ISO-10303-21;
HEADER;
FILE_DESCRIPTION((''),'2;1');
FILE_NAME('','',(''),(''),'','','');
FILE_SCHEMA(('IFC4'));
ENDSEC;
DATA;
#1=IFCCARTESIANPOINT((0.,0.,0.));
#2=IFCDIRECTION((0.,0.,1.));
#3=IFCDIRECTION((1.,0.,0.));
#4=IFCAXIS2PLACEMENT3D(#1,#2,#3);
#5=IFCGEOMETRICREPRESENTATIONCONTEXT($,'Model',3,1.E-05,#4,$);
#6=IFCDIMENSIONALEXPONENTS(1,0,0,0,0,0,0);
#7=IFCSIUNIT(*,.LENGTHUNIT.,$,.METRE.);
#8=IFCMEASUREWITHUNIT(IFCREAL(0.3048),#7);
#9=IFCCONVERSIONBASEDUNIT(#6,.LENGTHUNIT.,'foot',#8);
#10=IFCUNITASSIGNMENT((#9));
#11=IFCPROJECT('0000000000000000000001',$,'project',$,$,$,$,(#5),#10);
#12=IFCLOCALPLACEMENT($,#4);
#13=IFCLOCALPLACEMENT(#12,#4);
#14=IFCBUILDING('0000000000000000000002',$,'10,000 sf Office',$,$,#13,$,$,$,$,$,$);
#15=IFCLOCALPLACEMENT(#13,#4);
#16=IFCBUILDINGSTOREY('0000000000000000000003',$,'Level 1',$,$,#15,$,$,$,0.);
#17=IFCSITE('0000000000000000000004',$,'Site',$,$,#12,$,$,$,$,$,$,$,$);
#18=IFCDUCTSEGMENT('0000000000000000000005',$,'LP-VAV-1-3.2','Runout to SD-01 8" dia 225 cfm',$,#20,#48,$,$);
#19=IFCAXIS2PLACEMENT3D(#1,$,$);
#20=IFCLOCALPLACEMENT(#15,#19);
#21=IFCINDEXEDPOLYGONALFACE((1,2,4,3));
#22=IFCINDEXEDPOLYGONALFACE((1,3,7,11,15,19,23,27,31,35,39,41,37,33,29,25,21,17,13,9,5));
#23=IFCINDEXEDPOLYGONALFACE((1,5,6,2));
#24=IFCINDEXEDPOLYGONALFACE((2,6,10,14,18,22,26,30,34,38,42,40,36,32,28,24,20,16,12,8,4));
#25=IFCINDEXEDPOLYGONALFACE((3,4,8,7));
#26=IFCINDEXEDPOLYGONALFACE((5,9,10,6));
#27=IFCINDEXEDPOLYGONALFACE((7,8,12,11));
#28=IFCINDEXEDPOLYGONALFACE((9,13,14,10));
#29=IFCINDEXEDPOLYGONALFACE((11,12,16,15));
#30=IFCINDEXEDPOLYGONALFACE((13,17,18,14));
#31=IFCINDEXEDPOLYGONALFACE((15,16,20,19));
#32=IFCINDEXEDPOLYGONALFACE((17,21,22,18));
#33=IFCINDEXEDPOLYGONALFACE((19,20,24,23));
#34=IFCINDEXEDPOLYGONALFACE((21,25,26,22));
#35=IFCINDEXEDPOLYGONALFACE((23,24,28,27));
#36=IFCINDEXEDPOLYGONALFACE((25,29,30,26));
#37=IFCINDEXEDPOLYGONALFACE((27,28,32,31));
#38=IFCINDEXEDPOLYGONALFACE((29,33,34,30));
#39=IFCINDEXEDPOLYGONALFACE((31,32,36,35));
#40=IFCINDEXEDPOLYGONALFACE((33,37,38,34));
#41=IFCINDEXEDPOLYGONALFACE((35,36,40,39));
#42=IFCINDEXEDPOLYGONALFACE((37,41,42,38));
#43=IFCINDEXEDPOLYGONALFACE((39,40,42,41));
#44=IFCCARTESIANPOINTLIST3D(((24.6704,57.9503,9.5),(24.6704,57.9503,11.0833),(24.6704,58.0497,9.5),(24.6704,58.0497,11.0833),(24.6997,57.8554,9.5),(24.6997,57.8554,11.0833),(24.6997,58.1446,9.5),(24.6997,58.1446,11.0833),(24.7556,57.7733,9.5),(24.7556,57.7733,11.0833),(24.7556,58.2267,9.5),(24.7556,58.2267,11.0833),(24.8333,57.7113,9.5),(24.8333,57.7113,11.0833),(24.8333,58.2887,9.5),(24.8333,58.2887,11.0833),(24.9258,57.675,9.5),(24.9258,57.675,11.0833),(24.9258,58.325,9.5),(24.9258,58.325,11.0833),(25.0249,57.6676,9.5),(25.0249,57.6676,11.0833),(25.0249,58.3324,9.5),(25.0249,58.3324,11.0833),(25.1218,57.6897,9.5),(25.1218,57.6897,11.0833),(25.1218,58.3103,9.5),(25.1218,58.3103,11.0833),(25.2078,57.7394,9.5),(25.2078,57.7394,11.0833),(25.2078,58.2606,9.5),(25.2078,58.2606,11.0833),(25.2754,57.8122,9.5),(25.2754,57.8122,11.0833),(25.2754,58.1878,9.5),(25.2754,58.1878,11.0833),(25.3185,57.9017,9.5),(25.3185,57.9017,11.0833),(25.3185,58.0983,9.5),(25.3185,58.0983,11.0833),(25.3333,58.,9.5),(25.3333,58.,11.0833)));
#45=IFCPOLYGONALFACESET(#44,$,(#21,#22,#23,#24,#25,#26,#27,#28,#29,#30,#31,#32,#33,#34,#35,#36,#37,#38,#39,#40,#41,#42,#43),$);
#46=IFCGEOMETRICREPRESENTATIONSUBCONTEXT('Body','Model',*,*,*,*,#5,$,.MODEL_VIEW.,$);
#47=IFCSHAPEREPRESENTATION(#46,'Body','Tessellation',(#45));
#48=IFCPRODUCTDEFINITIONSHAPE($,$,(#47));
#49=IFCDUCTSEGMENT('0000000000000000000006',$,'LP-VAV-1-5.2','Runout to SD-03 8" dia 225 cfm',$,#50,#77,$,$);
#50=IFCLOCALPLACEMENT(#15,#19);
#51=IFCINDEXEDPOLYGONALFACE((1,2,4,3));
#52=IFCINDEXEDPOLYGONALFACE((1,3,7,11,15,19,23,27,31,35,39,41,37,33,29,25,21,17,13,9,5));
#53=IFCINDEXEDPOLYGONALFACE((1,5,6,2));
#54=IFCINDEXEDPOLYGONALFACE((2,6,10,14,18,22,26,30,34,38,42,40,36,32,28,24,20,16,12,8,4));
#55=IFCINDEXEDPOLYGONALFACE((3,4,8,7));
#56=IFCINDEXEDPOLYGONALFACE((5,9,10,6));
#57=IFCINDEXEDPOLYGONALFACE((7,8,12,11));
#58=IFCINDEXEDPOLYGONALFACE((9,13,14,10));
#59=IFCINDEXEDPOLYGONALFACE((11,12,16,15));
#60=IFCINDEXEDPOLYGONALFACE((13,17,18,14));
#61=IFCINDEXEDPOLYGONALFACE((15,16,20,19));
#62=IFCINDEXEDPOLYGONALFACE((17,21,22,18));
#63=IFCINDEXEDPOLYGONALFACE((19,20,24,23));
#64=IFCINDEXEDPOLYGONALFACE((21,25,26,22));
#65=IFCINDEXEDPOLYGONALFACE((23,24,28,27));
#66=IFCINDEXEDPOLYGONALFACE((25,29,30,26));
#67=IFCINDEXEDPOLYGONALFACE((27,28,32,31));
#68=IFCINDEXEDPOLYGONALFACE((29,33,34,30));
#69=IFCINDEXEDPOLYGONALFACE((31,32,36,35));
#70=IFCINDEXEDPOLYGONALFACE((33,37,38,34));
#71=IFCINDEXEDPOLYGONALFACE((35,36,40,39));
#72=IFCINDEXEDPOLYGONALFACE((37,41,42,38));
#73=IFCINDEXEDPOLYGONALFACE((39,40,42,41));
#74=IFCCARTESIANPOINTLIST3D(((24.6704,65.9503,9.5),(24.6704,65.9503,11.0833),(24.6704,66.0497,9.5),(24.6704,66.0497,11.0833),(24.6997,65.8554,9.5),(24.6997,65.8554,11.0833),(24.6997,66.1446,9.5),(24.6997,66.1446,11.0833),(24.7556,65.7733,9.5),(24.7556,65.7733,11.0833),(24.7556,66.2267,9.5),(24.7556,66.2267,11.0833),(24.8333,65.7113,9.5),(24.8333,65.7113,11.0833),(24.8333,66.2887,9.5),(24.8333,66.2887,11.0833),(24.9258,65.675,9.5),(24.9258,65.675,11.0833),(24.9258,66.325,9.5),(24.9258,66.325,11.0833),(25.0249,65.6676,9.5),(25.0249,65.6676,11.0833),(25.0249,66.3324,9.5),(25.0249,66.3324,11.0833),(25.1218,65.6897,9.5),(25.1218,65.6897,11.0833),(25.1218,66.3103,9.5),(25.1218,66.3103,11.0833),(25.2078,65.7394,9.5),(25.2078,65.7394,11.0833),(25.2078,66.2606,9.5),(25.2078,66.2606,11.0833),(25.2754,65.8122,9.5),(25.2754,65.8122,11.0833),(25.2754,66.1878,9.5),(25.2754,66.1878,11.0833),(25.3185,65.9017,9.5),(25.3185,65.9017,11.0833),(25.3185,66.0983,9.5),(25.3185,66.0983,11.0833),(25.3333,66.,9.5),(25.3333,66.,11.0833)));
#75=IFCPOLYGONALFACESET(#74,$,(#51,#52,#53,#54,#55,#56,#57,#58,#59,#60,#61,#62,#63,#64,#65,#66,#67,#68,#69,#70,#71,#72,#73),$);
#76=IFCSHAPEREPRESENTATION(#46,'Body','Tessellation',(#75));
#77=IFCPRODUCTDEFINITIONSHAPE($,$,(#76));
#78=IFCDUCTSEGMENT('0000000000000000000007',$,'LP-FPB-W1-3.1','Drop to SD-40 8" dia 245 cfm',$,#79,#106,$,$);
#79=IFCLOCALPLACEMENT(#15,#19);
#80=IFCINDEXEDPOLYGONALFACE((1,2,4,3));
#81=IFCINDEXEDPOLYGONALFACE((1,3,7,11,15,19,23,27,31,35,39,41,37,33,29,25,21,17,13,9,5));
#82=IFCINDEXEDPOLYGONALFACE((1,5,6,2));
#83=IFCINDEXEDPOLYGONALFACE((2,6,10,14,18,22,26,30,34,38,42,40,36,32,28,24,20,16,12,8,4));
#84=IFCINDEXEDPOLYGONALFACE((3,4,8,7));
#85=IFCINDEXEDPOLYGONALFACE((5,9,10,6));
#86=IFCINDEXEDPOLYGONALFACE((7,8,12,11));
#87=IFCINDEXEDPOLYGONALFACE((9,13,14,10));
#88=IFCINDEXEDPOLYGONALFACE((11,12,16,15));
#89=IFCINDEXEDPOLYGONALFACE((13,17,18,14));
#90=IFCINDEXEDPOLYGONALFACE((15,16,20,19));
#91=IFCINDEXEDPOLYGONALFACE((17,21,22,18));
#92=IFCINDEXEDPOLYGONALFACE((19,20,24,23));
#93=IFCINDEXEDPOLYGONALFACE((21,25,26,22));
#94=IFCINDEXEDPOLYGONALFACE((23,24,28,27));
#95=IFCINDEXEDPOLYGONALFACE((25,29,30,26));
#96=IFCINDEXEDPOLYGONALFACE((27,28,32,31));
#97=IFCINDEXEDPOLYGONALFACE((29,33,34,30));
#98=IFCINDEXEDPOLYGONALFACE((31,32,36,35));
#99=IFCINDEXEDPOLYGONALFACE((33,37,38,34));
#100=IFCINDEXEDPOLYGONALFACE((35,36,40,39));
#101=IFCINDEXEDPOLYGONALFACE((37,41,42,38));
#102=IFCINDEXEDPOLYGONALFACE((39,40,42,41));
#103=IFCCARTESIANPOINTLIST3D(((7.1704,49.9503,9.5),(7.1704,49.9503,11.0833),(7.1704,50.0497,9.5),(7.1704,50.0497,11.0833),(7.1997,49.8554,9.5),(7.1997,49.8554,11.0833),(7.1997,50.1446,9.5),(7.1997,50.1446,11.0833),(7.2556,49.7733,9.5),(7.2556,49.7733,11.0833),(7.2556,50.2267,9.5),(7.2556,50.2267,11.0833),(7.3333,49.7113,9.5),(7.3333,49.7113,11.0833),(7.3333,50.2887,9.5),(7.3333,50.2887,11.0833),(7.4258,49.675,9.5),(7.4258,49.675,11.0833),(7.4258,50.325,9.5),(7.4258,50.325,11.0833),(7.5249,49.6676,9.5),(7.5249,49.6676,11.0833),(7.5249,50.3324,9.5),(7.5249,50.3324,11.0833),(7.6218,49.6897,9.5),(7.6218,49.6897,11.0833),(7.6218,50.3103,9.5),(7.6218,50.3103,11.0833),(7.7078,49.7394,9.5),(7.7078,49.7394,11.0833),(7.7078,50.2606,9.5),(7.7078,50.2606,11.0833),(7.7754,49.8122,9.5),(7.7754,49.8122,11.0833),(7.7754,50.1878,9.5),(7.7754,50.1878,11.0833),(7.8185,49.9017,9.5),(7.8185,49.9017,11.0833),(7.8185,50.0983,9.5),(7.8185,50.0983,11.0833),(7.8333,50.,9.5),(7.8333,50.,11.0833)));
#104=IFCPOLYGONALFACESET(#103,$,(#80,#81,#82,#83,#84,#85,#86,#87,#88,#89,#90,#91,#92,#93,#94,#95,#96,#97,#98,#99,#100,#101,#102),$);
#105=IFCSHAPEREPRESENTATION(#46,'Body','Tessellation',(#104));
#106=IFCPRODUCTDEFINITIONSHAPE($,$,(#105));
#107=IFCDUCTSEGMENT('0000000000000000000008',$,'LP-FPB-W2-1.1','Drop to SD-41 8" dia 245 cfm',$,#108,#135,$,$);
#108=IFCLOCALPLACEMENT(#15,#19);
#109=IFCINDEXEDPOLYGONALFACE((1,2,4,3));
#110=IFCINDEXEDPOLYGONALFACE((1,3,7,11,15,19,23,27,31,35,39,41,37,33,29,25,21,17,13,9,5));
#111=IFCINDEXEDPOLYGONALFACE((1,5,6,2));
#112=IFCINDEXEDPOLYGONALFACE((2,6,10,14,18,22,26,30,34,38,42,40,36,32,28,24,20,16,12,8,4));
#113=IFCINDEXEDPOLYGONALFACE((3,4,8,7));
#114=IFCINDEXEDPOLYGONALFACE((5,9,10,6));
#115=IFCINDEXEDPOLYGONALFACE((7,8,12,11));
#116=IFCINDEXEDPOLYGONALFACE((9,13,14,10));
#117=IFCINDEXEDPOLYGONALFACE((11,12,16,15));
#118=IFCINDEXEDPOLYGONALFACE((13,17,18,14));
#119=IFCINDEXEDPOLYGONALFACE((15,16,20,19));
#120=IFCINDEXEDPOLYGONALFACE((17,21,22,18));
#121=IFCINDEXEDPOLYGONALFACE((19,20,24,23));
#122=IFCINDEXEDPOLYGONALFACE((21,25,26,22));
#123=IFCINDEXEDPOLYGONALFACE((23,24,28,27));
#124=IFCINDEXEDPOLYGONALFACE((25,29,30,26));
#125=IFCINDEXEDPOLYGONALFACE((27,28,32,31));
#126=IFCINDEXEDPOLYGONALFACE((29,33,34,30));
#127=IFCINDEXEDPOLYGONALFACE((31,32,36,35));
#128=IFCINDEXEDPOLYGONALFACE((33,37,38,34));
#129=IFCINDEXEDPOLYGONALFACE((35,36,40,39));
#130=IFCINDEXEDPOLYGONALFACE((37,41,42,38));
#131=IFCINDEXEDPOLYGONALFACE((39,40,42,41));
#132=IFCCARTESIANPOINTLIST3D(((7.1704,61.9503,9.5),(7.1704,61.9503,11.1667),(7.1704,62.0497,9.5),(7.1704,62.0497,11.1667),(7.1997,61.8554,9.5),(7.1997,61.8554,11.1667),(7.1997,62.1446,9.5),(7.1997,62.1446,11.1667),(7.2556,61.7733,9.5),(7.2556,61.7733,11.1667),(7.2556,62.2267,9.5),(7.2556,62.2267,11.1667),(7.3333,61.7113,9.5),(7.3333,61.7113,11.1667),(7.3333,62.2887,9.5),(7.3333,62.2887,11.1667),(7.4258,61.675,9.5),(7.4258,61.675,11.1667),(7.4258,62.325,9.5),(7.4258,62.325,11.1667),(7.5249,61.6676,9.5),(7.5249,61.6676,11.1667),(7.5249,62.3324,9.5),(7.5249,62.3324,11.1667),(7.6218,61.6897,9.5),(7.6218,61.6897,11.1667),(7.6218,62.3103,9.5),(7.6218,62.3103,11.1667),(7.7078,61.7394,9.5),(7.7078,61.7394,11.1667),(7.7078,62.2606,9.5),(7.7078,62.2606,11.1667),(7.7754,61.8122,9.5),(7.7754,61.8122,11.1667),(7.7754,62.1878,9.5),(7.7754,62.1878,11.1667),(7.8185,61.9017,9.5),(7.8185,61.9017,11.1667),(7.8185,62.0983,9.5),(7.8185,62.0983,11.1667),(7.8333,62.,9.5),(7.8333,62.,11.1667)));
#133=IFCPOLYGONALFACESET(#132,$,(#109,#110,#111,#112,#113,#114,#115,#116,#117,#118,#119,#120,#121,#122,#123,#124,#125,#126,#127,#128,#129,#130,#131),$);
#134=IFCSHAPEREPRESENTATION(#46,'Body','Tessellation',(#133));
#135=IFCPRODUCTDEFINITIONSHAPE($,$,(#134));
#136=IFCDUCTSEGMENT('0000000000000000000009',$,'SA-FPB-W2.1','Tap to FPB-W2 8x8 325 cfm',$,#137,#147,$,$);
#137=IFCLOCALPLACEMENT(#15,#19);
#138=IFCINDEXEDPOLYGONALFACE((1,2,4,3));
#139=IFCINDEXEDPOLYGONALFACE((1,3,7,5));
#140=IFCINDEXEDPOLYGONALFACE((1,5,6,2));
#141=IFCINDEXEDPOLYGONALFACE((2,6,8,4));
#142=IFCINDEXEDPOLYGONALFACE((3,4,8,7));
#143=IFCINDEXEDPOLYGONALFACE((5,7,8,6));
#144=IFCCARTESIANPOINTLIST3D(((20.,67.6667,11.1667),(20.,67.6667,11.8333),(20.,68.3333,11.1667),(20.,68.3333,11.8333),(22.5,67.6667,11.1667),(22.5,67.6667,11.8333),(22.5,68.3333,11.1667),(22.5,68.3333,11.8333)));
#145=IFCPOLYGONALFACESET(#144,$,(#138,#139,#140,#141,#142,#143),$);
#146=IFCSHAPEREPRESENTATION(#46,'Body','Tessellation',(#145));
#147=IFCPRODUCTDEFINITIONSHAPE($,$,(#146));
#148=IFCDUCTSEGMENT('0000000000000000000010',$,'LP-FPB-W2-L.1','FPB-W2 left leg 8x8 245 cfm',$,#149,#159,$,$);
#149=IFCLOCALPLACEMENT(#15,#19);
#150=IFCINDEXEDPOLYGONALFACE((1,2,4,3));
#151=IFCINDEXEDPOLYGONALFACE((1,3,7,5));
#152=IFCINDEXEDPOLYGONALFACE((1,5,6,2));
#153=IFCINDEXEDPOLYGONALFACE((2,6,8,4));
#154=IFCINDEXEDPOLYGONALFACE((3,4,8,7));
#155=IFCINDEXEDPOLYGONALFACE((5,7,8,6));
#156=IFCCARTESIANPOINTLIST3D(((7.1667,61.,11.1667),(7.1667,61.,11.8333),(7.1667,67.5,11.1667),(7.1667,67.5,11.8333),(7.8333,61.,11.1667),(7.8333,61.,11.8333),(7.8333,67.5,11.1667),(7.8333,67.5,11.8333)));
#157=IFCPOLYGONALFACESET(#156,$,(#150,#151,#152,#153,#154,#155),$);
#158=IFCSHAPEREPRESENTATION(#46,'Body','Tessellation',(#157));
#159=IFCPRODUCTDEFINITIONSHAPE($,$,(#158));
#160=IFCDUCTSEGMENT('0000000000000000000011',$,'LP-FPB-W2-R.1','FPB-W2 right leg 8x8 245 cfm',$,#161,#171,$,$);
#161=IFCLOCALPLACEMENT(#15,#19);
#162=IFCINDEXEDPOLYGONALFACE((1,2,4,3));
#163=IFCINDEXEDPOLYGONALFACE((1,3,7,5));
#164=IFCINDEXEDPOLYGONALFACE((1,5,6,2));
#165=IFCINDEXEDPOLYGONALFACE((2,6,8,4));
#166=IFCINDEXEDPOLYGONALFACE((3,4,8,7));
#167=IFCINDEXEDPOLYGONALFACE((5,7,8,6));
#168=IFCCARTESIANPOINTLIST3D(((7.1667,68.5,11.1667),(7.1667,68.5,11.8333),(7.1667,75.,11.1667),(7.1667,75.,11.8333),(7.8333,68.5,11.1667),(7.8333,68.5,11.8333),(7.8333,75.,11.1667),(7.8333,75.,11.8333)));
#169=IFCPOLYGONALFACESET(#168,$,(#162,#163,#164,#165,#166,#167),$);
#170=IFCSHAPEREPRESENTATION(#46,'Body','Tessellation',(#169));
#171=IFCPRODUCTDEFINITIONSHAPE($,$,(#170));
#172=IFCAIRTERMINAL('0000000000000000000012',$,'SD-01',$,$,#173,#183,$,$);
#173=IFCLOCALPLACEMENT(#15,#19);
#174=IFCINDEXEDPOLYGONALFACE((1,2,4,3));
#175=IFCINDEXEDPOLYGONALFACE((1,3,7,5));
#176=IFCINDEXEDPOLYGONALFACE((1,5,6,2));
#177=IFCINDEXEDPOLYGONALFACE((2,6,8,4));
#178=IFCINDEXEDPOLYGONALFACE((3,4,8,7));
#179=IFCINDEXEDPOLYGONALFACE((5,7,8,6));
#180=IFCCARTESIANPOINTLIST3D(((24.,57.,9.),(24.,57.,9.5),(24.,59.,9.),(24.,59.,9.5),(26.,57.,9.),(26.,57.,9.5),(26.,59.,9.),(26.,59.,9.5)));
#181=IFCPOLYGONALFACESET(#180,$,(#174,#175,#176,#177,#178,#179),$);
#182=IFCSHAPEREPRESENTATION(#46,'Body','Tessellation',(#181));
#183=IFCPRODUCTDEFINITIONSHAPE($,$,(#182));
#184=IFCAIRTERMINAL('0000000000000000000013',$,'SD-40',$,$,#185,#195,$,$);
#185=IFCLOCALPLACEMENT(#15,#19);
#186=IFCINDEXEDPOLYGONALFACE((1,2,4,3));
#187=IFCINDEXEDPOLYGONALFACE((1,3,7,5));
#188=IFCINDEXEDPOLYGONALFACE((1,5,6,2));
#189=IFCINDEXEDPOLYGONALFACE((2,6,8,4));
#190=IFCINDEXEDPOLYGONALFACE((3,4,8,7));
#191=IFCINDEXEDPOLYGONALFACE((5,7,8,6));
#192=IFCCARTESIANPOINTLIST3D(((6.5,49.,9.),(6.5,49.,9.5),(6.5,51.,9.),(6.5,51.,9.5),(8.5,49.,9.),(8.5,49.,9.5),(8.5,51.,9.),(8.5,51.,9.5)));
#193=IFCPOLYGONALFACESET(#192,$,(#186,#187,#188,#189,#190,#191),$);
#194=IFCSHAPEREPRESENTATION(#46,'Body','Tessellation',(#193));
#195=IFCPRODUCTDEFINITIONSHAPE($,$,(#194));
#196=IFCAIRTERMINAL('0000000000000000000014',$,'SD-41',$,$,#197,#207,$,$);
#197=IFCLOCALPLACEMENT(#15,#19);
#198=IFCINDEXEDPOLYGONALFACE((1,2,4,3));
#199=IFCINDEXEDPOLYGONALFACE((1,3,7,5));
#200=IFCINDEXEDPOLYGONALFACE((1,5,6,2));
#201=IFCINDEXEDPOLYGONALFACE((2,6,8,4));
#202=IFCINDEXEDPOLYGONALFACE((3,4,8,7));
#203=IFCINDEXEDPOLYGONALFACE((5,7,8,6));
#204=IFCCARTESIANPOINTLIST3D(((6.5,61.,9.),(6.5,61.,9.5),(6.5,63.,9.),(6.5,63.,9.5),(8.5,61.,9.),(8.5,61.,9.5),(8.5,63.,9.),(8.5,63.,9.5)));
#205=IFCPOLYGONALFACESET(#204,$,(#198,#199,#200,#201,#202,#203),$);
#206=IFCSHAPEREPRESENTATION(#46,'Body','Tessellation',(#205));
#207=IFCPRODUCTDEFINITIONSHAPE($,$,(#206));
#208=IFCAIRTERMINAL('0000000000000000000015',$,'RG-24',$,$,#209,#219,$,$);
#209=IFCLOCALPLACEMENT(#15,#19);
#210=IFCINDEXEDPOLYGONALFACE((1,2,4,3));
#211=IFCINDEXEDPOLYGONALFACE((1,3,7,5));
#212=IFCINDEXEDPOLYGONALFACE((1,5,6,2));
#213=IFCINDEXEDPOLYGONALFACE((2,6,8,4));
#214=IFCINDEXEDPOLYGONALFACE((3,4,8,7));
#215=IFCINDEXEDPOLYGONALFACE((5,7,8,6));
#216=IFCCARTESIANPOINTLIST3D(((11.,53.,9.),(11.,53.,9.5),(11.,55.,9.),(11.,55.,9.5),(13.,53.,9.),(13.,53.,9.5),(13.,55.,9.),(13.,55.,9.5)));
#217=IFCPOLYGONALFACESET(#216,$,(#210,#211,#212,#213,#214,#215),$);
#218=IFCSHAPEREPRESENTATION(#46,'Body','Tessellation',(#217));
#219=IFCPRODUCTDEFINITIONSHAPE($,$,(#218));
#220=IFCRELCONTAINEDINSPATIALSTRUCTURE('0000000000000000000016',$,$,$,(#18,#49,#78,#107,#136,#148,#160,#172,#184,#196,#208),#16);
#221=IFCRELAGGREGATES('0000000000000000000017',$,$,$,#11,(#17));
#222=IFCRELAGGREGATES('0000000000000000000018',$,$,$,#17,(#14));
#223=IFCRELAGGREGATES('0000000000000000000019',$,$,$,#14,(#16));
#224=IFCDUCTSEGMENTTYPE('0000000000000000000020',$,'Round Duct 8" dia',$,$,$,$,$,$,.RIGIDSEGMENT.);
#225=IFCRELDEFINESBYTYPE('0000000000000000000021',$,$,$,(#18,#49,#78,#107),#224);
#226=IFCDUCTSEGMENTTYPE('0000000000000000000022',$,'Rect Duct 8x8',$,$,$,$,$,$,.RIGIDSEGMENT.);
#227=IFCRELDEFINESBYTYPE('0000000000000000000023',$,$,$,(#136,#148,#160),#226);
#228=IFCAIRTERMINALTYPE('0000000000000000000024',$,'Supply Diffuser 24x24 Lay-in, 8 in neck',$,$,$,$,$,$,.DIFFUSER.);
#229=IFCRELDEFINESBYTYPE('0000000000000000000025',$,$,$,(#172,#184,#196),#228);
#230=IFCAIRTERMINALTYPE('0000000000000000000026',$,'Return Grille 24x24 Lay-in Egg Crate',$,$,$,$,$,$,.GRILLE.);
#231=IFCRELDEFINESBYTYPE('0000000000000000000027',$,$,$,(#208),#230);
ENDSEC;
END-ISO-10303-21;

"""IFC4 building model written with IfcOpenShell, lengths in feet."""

from ifc_helpers import new_model, entity, si_unit, converted_unit, frame, origin_with_axes, place, context, subcontext, project, spatial, rectangle, circle, extrude, type_object, element, save


model = new_model("IFC4")

# Units and contexts
model_context = context("Model", 3, precision=1e-05, world=origin_with_axes())
body_context = subcontext(model_context, "Body", "Model", "MODEL_VIEW")
ifc_project = project(units=[converted_unit("LENGTHUNIT", "foot", entity("IfcReal", 0.3048), si_unit("LENGTHUNIT", "METRE"), dimensions=[1, 0, 0, 0, 0, 0, 0])], contexts=[model_context])

# Site, building, storey
site_placement = place(None, origin_with_axes())
site = spatial("IfcSite", under=ifc_project, at=site_placement, Name="Site")
building_placement = place(site_placement, origin_with_axes())
building = spatial("IfcBuilding", under=site, at=building_placement, Name="10,000 sf Office")
storey_placement = place(building_placement, origin_with_axes())
storey = spatial("IfcBuildingStorey", under=building, at=storey_placement, Name="Level 1", Elevation=0.0)

# Duct segments
duct_segment_type_1 = type_object("IfcDuctSegmentType", Name="Round Duct 8\" dia", PredefinedType="RIGIDSEGMENT")
for number, where, z_axis, x_axis, name, description in (
    (1, (25.0, 58.0, 11.0833), (0.0, 0.0, -1.0), (1.0, 0.0, 0.0), "LP-VAV-1-3.2", "Runout to SD-01 8\" dia 225 cfm"),
    (2, (25.0, 66.0, 11.0833), (0.0, 0.0, -1.0), (1.0, 0.0, 0.0), "LP-VAV-1-5.2", "Runout to SD-03 8\" dia 225 cfm"),
    (3, (7.5, 50.0, 11.0833), (0.0, 0.0, -1.0), (1.0, 0.0, 0.0), "LP-FPB-W1-3.1", "Drop to SD-40 8\" dia 245 cfm"),
):
    element("IfcDuctSegment", number, at=place(storey_placement, frame(where, z_axis=z_axis, x_axis=x_axis)), inside=storey, type_object=duct_segment_type_1, Name=name, Description=description, context=body_context, shape_type="SweptSolid", body=[
        extrude(circle(Radius=0.3333), None, (0.0, 0.0, 1.0), 1.5833),
    ])
duct_segment_1_placement = place(storey_placement, frame((7.5, 62.0, 11.1667), z_axis=(0.0, 0.0, -1.0), x_axis=(1.0, 0.0, 0.0)))
element("IfcDuctSegment", 4, at=duct_segment_1_placement, inside=storey, type_object=duct_segment_type_1, Name="LP-FPB-W2-1.1", Description="Drop to SD-41 8\" dia 245 cfm", context=body_context, shape_type="SweptSolid", body=[
    extrude(circle(Radius=0.3333), None, (0.0, 0.0, 1.0), 1.6667),
])
duct_segment_type_2 = type_object("IfcDuctSegmentType", Name="Rect Duct 8x8", PredefinedType="RIGIDSEGMENT")
duct_segment_2_placement = place(storey_placement, frame((22.5, 68.0, 11.5), z_axis=(-1.0, 0.0, 0.0), x_axis=(0.0, -1.0, 0.0)))
element("IfcDuctSegment", 5, at=duct_segment_2_placement, inside=storey, type_object=duct_segment_type_2, Name="SA-FPB-W2.1", Description="Tap to FPB-W2 8x8 325 cfm", context=body_context, shape_type="SweptSolid", body=[
    extrude(rectangle(XDim=0.6667, YDim=0.6667), None, (0.0, 0.0, 1.0), 2.5),
])
for number, where, z_axis, x_axis, name, description in (
    (6, (7.5, 67.5, 11.5), (0.0, -1.0, 0.0), (1.0, 0.0, 0.0), "LP-FPB-W2-L.1", "FPB-W2 left leg 8x8 245 cfm"),
    (7, (7.5, 68.5, 11.5), (0.0, 1.0, 0.0), (-1.0, 0.0, 0.0), "LP-FPB-W2-R.1", "FPB-W2 right leg 8x8 245 cfm"),
):
    element("IfcDuctSegment", number, at=place(storey_placement, frame(where, z_axis=z_axis, x_axis=x_axis)), inside=storey, type_object=duct_segment_type_2, Name=name, Description=description, context=body_context, shape_type="SweptSolid", body=[
        extrude(rectangle(XDim=0.6667, YDim=0.6667), None, (0.0, 0.0, 1.0), 6.5),
    ])

# Air terminals
air_terminal_type_1 = type_object("IfcAirTerminalType", Name="Supply Diffuser 24x24 Lay-in, 8 in neck", PredefinedType="DIFFUSER")
for number, where, z_axis, x_axis, name in (
    (8, (25.0, 58.0, 9.0), (0.0, 0.0, 1.0), (1.0, 0.0, 0.0), "SD-01"),
    (9, (7.5, 50.0, 9.0), (0.0, 0.0, 1.0), (1.0, 0.0, 0.0), "SD-40"),
    (10, (7.5, 62.0, 9.0), (0.0, 0.0, 1.0), (1.0, 0.0, 0.0), "SD-41"),
):
    element("IfcAirTerminal", number, at=place(storey_placement, frame(where, z_axis=z_axis, x_axis=x_axis)), inside=storey, type_object=air_terminal_type_1, Name=name, context=body_context, shape_type="SweptSolid", body=[
        extrude(rectangle(XDim=2.0, YDim=2.0), None, (0.0, 0.0, 1.0), 0.5),
    ])
air_terminal_type_2 = type_object("IfcAirTerminalType", Name="Return Grille 24x24 Lay-in Egg Crate", PredefinedType="GRILLE")
for number, where, z_axis, x_axis, name in (
    (11, (12.0, 54.0, 9.0), (0.0, 0.0, 1.0), (1.0, 0.0, 0.0), "RG-24"),
):
    element("IfcAirTerminal", number, at=place(storey_placement, frame(where, z_axis=z_axis, x_axis=x_axis)), inside=storey, type_object=air_terminal_type_2, Name=name, context=body_context, shape_type="SweptSolid", body=[
        extrude(rectangle(XDim=2.0, YDim=2.0), None, (0.0, 0.0, 1.0), 0.5),
    ])

save(model, "model.ifc")
